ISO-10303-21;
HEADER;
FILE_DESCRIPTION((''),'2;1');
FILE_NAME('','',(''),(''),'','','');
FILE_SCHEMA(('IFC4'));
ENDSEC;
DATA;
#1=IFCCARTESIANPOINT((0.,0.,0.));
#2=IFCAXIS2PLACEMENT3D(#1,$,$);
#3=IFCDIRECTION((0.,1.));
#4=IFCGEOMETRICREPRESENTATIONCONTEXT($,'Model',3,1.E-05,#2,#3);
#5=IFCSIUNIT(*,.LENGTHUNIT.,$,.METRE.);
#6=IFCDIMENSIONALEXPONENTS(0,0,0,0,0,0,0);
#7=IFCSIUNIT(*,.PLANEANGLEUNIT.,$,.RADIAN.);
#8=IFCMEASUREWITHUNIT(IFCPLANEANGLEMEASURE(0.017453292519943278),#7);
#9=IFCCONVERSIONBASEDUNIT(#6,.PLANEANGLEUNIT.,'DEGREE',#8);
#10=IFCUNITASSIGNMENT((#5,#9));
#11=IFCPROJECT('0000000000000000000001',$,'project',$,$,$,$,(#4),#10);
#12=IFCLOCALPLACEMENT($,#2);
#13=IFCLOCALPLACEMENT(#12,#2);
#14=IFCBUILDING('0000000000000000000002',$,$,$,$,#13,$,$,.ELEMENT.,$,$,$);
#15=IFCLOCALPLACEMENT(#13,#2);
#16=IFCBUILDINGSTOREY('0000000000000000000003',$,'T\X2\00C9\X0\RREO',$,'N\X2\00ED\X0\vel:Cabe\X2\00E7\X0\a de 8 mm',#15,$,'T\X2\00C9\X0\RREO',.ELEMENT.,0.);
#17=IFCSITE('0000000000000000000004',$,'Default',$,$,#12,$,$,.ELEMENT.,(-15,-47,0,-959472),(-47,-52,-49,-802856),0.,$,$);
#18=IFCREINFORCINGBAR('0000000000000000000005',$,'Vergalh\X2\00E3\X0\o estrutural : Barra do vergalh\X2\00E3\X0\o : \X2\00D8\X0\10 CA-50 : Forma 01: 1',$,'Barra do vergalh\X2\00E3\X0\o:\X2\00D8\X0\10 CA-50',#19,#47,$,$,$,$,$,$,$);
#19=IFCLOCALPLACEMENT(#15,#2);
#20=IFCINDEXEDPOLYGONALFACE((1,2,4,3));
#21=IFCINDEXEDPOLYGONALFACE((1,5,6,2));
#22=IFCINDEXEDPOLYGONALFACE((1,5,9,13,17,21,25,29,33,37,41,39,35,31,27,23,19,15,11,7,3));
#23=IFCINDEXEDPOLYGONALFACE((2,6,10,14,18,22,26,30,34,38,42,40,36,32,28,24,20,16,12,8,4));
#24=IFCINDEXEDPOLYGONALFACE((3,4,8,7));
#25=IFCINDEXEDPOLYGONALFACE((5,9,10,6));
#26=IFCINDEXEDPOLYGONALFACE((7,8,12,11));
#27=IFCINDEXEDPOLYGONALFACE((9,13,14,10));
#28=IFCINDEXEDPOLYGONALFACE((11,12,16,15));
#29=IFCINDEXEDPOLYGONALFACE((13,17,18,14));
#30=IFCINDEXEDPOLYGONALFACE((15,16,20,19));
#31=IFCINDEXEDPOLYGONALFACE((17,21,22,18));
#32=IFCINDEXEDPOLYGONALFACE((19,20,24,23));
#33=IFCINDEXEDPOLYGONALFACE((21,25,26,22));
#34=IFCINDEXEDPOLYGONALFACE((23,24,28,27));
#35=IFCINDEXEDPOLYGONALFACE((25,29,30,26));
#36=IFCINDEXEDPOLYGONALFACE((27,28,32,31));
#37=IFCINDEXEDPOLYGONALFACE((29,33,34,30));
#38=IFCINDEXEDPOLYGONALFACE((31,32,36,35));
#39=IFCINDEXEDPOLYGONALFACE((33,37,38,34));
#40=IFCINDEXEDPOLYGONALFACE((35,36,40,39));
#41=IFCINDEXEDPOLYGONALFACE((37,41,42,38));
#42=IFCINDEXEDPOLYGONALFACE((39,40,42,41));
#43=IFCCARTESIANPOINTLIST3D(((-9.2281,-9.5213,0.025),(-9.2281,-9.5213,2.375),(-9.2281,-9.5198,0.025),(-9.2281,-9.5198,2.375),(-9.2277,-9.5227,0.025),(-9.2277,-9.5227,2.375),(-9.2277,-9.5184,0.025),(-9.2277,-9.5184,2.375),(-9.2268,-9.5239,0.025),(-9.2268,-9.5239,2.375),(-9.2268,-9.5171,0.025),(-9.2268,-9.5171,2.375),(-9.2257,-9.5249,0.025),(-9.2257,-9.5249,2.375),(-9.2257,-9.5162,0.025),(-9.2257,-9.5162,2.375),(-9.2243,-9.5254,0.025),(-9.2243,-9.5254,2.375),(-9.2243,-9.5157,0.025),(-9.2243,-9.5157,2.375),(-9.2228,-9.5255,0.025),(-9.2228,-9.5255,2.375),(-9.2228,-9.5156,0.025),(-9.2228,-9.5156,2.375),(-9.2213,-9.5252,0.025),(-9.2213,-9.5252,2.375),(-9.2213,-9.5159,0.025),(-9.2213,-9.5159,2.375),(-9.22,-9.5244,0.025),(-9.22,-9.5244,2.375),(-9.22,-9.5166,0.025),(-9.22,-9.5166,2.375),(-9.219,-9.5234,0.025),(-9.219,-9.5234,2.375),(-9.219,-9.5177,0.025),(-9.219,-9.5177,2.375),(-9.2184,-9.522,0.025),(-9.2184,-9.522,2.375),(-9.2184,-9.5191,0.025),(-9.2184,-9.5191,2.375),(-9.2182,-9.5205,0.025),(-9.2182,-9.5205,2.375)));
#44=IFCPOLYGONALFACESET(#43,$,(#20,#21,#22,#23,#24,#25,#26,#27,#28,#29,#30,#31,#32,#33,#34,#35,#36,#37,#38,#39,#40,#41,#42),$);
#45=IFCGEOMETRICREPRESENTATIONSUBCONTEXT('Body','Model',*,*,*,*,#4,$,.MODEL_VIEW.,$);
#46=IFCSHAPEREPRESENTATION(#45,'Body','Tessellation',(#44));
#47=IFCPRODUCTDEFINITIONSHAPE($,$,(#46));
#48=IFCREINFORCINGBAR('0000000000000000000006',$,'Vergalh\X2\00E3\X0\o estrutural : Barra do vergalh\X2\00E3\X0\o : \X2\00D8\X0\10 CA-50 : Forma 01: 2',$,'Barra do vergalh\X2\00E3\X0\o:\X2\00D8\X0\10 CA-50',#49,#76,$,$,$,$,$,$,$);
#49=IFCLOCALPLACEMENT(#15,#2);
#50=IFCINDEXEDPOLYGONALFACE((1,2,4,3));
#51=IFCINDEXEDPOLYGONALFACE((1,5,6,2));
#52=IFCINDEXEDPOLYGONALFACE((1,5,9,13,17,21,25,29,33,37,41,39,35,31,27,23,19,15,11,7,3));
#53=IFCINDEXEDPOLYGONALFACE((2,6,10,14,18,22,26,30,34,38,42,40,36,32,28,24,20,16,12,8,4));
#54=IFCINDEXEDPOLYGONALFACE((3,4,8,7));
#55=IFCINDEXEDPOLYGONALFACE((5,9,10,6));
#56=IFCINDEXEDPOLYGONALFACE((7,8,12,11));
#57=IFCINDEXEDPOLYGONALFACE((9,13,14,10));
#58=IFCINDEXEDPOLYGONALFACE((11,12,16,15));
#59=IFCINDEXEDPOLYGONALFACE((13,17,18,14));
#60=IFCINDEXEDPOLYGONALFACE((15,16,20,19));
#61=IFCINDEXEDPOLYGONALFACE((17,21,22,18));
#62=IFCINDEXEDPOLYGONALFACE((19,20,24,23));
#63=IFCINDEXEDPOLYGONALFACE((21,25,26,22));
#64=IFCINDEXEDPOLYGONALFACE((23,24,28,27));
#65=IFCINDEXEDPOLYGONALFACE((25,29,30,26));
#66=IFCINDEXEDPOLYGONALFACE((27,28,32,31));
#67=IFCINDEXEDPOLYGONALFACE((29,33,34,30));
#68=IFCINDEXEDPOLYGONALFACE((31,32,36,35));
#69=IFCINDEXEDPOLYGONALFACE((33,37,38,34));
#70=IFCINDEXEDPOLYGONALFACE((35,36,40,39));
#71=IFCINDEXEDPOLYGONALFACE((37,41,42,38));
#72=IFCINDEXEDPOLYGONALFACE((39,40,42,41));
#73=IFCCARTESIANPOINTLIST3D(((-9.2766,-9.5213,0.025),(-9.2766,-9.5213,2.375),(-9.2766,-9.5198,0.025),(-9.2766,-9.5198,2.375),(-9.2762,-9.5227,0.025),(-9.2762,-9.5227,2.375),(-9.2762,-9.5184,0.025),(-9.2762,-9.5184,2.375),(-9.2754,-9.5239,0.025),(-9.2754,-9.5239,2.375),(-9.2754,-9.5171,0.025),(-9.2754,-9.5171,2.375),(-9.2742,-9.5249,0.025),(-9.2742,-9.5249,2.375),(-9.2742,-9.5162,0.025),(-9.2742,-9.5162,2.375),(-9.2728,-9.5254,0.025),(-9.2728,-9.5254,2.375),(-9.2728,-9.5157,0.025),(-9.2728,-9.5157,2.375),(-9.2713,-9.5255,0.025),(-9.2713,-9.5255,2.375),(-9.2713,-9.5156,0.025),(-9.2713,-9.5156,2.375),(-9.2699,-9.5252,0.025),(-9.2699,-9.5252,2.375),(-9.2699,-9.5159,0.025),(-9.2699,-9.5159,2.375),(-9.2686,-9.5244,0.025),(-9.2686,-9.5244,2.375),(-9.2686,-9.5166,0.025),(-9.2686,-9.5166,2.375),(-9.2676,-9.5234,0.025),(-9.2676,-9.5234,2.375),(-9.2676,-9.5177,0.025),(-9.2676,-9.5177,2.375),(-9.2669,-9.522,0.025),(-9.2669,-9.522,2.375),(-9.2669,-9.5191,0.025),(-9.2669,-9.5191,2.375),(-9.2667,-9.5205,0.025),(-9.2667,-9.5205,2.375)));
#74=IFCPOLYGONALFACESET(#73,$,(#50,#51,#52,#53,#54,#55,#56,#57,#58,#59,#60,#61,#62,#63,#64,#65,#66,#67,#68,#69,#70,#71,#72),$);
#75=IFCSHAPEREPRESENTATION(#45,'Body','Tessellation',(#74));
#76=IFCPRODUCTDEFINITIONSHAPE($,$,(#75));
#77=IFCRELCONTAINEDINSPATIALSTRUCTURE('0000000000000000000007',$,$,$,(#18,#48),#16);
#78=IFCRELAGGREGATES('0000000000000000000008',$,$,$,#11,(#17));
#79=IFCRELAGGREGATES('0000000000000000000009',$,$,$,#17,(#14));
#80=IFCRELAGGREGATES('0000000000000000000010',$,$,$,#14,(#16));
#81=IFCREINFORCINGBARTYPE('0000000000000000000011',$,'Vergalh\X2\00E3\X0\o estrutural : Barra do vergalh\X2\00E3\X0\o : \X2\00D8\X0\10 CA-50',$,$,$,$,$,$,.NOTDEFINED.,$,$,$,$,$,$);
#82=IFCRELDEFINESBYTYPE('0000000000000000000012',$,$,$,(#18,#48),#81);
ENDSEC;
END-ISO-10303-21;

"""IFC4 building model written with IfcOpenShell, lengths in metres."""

from ifc_helpers import new_model, entity, si_unit, converted_unit, direction, origin, place, context, subcontext, project, spatial, type_object, element, save


model = new_model("IFC4")

# Units and contexts
model_context = context("Model", 3, precision=1e-05, world=origin(), true_north=direction((0.0, 1.0)))
body_context = subcontext(model_context, "Body", "Model", "MODEL_VIEW")
ifc_project = project(units=[si_unit("LENGTHUNIT", "METRE"), converted_unit("PLANEANGLEUNIT", "DEGREE", entity("IfcPlaneAngleMeasure", 0.017453292519943278), si_unit("PLANEANGLEUNIT", "RADIAN"), dimensions=[0, 0, 0, 0, 0, 0, 0])], contexts=[model_context])

# Site, building, storey
site_placement = place(None, origin())
site = spatial("IfcSite", under=ifc_project, at=site_placement, Name="Default", CompositionType="ELEMENT", RefLatitude=(-15, -47, 0, -959472), RefLongitude=(-47, -52, -49, -802856), RefElevation=0.0)
building_placement = place(site_placement, origin())
building = spatial("IfcBuilding", under=site, at=building_placement, CompositionType="ELEMENT")
storey_placement = place(building_placement, origin())
storey = spatial("IfcBuildingStorey", under=building, at=storey_placement, Name="TÉRREO", ObjectType="Nível:Cabeça de 8 mm", LongName="TÉRREO", CompositionType="ELEMENT", Elevation=0.0)

# Reinforcing bars
reinforcing_bar_type_1 = type_object("IfcReinforcingBarType", Name="Vergalhão estrutural : Barra do vergalhão : Ø10 CA-50", PredefinedType="NOTDEFINED")
reinforcing_bar_1_placement = place(storey_placement, origin())
element("IfcReinforcingBar", 1, at=reinforcing_bar_1_placement, inside=storey, type_object=reinforcing_bar_type_1, Name="Vergalhão estrutural : Barra do vergalhão : Ø10 CA-50 : Forma 01: 1", ObjectType="Barra do vergalhão:Ø10 CA-50", context=body_context, shape_type="AdvancedSweptSolid", body=[
    entity("IfcSweptDiskSolid", entity("IfcIndexedPolyCurve", entity("IfcCartesianPointList3D", [[-9.2232, -9.5205, 0.025], [-9.2232, -9.5205, 2.375]]), None, False), 0.005, None, 0.0, 1.0),
])
reinforcing_bar_2_placement = place(storey_placement, origin())
element("IfcReinforcingBar", 2, at=reinforcing_bar_2_placement, inside=storey, type_object=reinforcing_bar_type_1, Name="Vergalhão estrutural : Barra do vergalhão : Ø10 CA-50 : Forma 01: 2", ObjectType="Barra do vergalhão:Ø10 CA-50", context=body_context, shape_type="AdvancedSweptSolid", body=[
    entity("IfcSweptDiskSolid", entity("IfcIndexedPolyCurve", entity("IfcCartesianPointList3D", [[-9.2717, -9.5205, 0.025], [-9.2717, -9.5205, 2.375]]), None, False), 0.005, None, 0.0, 1.0),
])

save(model, "model.ifc")
